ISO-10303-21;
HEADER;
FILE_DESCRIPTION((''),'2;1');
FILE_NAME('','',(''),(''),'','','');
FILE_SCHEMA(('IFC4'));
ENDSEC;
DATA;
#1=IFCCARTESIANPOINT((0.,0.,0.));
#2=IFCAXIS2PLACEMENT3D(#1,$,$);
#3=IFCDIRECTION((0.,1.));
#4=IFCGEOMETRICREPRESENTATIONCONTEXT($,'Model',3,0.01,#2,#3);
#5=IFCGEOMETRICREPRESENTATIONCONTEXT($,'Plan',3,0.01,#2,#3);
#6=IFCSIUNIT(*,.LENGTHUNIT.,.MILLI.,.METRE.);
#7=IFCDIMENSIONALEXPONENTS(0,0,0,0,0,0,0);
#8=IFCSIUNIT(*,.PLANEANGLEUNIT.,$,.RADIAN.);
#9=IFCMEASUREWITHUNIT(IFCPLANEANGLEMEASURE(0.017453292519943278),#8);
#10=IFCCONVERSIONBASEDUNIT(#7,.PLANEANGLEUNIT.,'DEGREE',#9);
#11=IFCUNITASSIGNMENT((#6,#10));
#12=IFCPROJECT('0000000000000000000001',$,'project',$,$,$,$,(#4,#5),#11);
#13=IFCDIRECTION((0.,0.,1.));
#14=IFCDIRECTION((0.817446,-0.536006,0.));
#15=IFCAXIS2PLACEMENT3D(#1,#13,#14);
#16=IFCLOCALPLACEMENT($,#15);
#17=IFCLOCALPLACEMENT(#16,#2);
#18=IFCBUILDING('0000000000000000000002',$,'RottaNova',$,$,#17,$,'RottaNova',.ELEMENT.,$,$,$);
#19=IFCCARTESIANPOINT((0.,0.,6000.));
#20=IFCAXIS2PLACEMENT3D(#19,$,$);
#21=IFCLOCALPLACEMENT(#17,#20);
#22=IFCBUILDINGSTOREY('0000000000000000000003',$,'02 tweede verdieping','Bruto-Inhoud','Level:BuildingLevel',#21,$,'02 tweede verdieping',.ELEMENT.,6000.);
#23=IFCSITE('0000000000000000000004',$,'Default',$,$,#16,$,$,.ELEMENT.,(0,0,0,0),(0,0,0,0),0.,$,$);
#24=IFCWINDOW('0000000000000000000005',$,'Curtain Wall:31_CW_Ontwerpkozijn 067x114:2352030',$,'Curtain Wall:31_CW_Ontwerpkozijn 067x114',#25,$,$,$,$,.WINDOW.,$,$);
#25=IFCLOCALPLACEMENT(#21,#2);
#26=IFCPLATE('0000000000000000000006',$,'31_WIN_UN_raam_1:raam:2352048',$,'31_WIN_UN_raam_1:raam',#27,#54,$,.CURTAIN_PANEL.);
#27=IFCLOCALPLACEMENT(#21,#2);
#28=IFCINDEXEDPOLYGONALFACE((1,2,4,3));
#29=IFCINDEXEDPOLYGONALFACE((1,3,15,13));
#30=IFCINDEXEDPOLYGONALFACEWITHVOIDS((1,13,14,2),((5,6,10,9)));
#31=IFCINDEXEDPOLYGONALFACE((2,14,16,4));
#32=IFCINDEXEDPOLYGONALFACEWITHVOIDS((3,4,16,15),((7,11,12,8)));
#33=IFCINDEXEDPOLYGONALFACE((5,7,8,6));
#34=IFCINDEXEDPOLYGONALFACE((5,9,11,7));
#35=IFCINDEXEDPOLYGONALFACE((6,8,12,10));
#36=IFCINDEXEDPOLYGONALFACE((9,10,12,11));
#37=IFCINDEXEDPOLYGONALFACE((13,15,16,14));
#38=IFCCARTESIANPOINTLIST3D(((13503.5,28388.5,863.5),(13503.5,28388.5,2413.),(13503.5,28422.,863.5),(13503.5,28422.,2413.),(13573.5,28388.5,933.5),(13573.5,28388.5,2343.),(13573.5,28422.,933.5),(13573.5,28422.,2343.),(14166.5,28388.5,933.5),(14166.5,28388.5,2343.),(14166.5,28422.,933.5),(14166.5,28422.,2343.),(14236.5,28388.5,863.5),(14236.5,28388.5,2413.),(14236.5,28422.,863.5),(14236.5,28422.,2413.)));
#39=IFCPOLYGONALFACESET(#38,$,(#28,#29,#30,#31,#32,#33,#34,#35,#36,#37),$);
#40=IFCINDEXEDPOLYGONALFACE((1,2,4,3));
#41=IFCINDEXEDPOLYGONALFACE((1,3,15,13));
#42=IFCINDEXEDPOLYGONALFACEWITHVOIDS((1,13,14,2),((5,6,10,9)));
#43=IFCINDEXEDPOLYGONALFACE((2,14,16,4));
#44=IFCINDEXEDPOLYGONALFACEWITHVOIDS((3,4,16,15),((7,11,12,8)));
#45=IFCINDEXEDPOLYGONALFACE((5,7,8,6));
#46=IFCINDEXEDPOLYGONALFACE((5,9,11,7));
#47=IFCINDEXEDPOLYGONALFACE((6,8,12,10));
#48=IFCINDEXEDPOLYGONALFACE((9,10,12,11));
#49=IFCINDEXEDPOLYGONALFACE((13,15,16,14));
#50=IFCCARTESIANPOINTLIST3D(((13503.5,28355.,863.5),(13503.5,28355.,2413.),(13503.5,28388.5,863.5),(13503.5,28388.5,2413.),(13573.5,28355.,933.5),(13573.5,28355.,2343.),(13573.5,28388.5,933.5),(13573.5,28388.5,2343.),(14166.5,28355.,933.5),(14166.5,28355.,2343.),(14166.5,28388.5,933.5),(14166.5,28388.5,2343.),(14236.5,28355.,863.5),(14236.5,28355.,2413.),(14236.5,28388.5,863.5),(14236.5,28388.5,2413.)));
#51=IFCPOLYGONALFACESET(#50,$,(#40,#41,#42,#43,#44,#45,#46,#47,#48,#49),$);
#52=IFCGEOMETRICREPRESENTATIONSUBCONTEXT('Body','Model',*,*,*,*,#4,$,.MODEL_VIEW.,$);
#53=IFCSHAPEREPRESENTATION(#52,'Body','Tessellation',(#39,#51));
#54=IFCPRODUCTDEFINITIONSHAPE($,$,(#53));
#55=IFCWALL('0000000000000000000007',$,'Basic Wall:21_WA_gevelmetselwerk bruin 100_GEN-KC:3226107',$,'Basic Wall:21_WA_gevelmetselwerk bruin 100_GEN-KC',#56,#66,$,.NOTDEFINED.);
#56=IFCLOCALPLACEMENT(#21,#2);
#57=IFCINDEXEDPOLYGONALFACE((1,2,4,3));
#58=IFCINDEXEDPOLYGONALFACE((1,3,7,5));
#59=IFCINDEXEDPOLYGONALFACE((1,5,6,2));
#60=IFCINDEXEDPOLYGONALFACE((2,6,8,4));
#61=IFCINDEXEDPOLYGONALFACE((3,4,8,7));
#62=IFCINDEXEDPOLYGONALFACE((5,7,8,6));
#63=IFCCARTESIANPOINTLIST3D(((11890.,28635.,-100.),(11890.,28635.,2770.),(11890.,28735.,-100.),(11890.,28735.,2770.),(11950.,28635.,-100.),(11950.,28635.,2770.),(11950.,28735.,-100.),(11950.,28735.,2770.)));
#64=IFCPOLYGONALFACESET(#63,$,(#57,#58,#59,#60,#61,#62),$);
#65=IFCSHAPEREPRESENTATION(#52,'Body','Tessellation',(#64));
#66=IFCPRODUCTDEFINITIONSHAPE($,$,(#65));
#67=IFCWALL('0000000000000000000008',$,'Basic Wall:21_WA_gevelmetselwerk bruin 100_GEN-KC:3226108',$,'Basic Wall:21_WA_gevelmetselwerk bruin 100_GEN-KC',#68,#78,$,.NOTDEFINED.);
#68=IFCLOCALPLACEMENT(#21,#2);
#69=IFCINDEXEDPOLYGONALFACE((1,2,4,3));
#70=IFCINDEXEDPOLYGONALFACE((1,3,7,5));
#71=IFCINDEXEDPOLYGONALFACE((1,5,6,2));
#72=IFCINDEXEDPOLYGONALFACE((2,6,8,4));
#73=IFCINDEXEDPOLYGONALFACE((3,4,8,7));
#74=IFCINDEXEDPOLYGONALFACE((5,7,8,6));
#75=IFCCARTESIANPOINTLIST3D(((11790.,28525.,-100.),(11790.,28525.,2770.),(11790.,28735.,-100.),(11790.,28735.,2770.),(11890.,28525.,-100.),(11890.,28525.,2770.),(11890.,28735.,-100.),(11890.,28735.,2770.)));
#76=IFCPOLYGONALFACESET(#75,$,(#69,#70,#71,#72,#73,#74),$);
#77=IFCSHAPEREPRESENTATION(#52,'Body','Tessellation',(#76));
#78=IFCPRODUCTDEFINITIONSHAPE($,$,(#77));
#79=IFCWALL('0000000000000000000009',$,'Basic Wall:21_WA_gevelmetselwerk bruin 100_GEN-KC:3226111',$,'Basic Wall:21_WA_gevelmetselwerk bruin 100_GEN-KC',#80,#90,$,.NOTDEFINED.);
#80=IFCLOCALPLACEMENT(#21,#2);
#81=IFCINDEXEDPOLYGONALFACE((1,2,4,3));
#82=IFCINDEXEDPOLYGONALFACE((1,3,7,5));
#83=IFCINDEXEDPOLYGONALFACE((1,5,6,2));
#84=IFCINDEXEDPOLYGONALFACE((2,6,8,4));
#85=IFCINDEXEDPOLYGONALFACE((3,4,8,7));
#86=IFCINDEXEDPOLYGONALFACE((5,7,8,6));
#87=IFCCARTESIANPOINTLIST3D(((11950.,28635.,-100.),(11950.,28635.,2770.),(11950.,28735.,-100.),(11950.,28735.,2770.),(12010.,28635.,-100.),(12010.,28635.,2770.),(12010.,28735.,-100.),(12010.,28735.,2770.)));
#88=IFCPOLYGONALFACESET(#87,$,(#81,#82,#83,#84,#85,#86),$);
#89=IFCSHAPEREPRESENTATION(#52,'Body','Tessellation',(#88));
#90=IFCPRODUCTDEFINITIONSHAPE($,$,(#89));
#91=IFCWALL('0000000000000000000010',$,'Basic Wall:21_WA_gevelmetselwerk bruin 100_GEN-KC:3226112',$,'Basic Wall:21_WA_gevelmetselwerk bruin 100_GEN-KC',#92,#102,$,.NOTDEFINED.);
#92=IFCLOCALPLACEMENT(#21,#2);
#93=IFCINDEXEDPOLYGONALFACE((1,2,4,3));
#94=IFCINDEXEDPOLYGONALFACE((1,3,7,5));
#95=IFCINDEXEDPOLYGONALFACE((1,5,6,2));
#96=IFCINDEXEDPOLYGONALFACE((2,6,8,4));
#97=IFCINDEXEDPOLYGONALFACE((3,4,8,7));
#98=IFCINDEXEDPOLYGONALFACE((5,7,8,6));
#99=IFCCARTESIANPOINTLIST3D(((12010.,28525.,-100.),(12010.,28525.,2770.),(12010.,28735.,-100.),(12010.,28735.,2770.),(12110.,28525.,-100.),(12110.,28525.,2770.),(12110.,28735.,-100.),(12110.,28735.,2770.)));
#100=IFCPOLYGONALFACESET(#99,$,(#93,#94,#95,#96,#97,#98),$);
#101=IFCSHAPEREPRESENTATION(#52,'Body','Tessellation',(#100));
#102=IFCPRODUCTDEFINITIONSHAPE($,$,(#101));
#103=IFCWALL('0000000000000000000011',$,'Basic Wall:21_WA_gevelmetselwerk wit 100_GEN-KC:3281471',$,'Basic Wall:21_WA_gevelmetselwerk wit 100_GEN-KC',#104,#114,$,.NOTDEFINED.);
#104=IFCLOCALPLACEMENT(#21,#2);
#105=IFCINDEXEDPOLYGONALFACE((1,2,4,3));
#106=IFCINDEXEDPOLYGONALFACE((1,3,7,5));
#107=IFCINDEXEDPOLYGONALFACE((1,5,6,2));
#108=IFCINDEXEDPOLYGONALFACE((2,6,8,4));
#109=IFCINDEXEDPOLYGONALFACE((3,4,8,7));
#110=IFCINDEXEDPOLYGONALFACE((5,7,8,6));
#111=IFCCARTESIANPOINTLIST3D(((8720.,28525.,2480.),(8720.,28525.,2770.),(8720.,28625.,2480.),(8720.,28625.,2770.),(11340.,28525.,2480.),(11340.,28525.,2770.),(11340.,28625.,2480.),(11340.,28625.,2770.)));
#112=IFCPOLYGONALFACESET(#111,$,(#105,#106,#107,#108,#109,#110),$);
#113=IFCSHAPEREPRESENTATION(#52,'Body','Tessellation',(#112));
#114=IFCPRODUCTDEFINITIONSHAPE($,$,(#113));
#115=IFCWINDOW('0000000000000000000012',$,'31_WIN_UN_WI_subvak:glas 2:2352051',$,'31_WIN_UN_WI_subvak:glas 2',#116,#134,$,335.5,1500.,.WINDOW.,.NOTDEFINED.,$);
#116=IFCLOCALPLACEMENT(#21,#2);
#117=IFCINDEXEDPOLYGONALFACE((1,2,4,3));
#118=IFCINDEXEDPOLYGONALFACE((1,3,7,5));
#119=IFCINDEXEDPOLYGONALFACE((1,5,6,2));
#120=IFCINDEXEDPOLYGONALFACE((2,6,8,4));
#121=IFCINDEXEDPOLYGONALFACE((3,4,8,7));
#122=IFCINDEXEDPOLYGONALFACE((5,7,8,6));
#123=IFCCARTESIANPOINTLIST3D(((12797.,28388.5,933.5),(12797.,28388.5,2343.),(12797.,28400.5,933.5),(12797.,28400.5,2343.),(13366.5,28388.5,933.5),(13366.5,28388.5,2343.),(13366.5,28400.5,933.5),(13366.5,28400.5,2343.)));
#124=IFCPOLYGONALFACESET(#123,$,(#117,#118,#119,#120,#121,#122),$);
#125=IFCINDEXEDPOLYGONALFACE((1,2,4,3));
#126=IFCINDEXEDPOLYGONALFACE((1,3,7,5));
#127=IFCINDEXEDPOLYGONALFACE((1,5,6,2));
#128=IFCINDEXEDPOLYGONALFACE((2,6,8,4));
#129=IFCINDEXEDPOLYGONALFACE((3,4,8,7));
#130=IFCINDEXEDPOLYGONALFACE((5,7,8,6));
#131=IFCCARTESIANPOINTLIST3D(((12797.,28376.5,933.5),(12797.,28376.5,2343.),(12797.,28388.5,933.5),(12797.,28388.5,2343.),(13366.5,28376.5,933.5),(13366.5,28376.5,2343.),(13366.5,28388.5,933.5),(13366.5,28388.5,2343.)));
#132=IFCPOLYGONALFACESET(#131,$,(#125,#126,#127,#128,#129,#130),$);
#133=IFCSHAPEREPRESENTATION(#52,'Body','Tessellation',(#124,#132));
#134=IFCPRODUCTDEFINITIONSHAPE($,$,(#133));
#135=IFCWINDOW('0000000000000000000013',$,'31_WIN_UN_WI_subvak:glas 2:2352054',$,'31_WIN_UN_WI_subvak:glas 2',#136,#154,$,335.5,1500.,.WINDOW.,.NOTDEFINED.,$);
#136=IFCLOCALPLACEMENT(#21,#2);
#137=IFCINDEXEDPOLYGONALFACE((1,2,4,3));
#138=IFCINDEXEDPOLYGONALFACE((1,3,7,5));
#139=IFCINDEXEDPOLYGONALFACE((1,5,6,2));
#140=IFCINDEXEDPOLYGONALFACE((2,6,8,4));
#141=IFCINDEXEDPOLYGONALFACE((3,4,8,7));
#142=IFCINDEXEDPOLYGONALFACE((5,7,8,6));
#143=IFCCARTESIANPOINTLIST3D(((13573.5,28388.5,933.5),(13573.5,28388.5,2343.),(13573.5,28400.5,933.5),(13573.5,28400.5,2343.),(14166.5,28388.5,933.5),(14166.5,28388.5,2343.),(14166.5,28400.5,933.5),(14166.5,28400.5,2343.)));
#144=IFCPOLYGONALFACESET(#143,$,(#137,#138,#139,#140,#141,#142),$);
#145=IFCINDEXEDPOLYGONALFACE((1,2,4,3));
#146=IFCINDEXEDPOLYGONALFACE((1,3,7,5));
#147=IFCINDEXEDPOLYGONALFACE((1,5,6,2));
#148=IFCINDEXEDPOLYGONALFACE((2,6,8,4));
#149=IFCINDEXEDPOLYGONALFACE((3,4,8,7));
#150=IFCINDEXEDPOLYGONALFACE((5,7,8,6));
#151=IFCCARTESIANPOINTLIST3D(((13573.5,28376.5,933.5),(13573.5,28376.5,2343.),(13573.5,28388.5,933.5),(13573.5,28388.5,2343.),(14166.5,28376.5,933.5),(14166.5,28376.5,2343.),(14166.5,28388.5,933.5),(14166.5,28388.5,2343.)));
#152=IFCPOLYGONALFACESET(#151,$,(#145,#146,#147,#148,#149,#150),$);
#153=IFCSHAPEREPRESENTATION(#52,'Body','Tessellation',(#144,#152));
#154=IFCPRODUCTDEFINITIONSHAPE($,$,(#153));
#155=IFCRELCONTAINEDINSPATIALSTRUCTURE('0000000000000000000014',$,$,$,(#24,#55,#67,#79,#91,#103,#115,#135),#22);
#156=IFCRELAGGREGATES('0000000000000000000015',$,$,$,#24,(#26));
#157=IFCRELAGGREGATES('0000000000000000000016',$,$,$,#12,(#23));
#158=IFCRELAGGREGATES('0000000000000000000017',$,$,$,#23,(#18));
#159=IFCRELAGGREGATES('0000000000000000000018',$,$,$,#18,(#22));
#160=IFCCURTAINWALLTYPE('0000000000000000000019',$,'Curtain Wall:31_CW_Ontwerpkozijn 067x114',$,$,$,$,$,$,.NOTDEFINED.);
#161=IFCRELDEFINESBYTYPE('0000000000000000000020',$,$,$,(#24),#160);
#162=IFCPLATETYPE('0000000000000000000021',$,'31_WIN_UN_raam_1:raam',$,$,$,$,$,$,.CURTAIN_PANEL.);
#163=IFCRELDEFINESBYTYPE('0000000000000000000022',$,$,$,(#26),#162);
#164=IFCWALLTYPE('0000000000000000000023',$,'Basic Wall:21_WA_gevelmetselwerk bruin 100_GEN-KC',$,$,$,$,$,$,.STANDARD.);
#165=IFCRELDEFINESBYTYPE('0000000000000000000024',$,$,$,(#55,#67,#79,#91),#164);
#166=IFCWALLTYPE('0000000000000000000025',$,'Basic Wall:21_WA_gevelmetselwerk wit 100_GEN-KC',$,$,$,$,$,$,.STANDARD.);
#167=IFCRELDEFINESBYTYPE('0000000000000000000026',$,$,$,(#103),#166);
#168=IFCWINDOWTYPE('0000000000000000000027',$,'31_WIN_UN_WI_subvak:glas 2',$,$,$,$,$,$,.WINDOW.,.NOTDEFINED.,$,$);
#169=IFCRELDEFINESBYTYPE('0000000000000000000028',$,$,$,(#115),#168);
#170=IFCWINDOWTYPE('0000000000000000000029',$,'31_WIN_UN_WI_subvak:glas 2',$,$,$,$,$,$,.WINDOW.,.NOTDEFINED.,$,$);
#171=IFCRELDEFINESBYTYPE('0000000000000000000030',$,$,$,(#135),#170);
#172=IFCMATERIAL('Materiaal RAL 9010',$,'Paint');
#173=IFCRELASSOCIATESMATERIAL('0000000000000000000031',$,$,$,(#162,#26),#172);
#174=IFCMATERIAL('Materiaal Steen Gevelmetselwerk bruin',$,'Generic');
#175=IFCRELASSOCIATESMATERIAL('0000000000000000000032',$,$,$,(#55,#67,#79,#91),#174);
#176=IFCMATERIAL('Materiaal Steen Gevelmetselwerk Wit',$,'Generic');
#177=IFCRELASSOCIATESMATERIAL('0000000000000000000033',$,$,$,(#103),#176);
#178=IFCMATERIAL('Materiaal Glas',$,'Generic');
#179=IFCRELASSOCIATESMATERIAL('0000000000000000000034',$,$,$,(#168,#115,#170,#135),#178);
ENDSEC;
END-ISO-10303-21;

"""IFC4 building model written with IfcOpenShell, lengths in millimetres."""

from ifc_helpers import new_model, entity, si_unit, converted_unit, direction, frame, origin, place, context, subcontext, project, spatial, indexed_curve, outline, extrude, source, transform, mapped, material, type_object, type_shapes, element, aggregate, save


model = new_model("IFC4")

# Units and contexts
model_context = context("Model", 3, precision=0.01, world=origin(), true_north=direction((0.0, 1.0)))
plan_context = context("Plan", 3, precision=0.01, world=origin(), true_north=direction((0.0, 1.0)))
body_context = subcontext(model_context, "Body", "Model", "MODEL_VIEW")
ifc_project = project(units=[si_unit("LENGTHUNIT", "METRE", prefix="MILLI"), converted_unit("PLANEANGLEUNIT", "DEGREE", entity("IfcPlaneAngleMeasure", 0.017453292519943278), si_unit("PLANEANGLEUNIT", "RADIAN"), dimensions=[0, 0, 0, 0, 0, 0, 0])], contexts=[model_context, plan_context])

# Site, building, storey
site_placement = place(None, frame((0.0, 0.0, 0.0), z_axis=(0.0, 0.0, 1.0), x_axis=(0.817446, -0.536006, 0.0)))
site = spatial("IfcSite", under=ifc_project, at=site_placement, Name="Default", CompositionType="ELEMENT", RefLatitude=(0, 0, 0, 0), RefLongitude=(0, 0, 0, 0), RefElevation=0.0)
building_placement = place(site_placement, origin())
building = spatial("IfcBuilding", under=site, at=building_placement, Name="RottaNova", LongName="RottaNova", CompositionType="ELEMENT")
storey_placement = place(building_placement, frame((0.0, 0.0, 6000.0)))
storey = spatial("IfcBuildingStorey", under=building, at=storey_placement, Name="02 tweede verdieping", Description="Bruto-Inhoud", ObjectType="Level:BuildingLevel", LongName="02 tweede verdieping", CompositionType="ELEMENT", Elevation=6000.0)

# Window
curtain_wall_type = type_object("IfcCurtainWallType", Name="Curtain Wall:31_CW_Ontwerpkozijn 067x114", PredefinedType="NOTDEFINED")
window_1_placement = place(storey_placement, frame((0.0, 0.0, -6000.0)))
window_1 = element("IfcWindow", 1, at=window_1_placement, inside=storey, type_object=curtain_wall_type, Name="Curtain Wall:31_CW_Ontwerpkozijn 067x114:2352030", ObjectType="Curtain Wall:31_CW_Ontwerpkozijn 067x114", PredefinedType="WINDOW")
ifc_material_1 = material(Name="Materiaal RAL 9010", Category="Paint")

# Plate
ifc_material_2 = material(Name="Materiaal Glas", Category="Generic")
plate_type_1 = type_object("IfcPlateType", Name="31_WIN_UN_raam_1:raam", PredefinedType="CURTAIN_PANEL", material=ifc_material_1)
shared_shape_1 = source(origin(), body_context, "Body", "SweptSolid", [
    extrude(outline(indexed_curve([(-366.5, -774.8), (366.5, -774.8), (366.5, 774.8), (-366.5, 774.8), (-366.5, -774.8)], self_intersect=False), holes=[indexed_curve([(-296.5, 704.8), (296.5, 704.8), (296.5, -704.8), (-296.5, -704.8), (-296.5, 704.8)], self_intersect=False)]), frame((0.0, 58.5, 774.8), z_axis=(0.0, 1.0, 0.0), x_axis=(1.0, 0.0, 0.0)), (0.0, 0.0, 1.0), 33.5),
    extrude(outline(indexed_curve([(-366.5, -774.8), (366.5, -774.8), (366.5, 774.8), (-366.5, 774.8), (-366.5, -774.8)], self_intersect=False), holes=[indexed_curve([(-296.5, 704.7), (296.5, 704.7), (296.5, -704.8), (-296.5, -704.8), (-296.5, 704.7)], self_intersect=False)]), frame((0.0, 25.0, 774.8), z_axis=(0.0, 1.0, 0.0), x_axis=(1.0, 0.0, 0.0)), (0.0, 0.0, 1.0), 33.5),
])
type_shapes(plate_type_1, [shared_shape_1])
plate_1_placement = place(window_1_placement, frame((13870.0, 28330.0, 6863.5)))
plate_1 = element("IfcPlate", 2, at=plate_1_placement, type_object=plate_type_1, material=ifc_material_1, Name="31_WIN_UN_raam_1:raam:2352048", ObjectType="31_WIN_UN_raam_1:raam", PredefinedType="CURTAIN_PANEL", context=body_context, shape_type="MappedRepresentation", body=[
    mapped(shared_shape_1, transform((0.0, 0.0, 0.0), scale=1.0)),
])
aggregate(window_1, [plate_1])

# Walls
ifc_material_3 = material(Name="Materiaal Steen Gevelmetselwerk bruin", Category="Generic")
wall_type_1 = type_object("IfcWallType", Name="Basic Wall:21_WA_gevelmetselwerk bruin 100_GEN-KC", PredefinedType="STANDARD")
wall_1_placement = place(storey_placement, frame((11890.0, 28685.0, -100.0)))
element("IfcWall", 3, at=wall_1_placement, inside=storey, type_object=wall_type_1, material=ifc_material_3, Name="Basic Wall:21_WA_gevelmetselwerk bruin 100_GEN-KC:3226107", ObjectType="Basic Wall:21_WA_gevelmetselwerk bruin 100_GEN-KC", PredefinedType="NOTDEFINED", context=body_context, shape_type="SweptSolid", body=[
    extrude(outline(indexed_curve([(60.0, 50.0), (0.0, 50.0), (0.0, -50.0), (60.0, -50.0), (60.0, 50.0)], self_intersect=False)), origin(), (0.0, 0.0, 1.0), 2870.0),
])
wall_2_placement = place(storey_placement, frame((11840.0, 28735.0, -100.0), z_axis=(0.0, 0.0, 1.0), x_axis=(0.0, -1.0, 0.0)))
element("IfcWall", 4, at=wall_2_placement, inside=storey, type_object=wall_type_1, material=ifc_material_3, Name="Basic Wall:21_WA_gevelmetselwerk bruin 100_GEN-KC:3226108", ObjectType="Basic Wall:21_WA_gevelmetselwerk bruin 100_GEN-KC", PredefinedType="NOTDEFINED", context=body_context, shape_type="SweptSolid", body=[
    extrude(outline(indexed_curve([(210.0, 50.0), (0.0, 50.0), (0.0, -50.0), (210.0, -50.0), (210.0, 50.0)], self_intersect=False)), origin(), (0.0, 0.0, 1.0), 2870.0),
])
wall_3_placement = place(storey_placement, frame((12010.0, 28685.0, -100.0), z_axis=(0.0, 0.0, 1.0), x_axis=(-1.0, 0.0, 0.0)))
element("IfcWall", 5, at=wall_3_placement, inside=storey, type_object=wall_type_1, material=ifc_material_3, Name="Basic Wall:21_WA_gevelmetselwerk bruin 100_GEN-KC:3226111", ObjectType="Basic Wall:21_WA_gevelmetselwerk bruin 100_GEN-KC", PredefinedType="NOTDEFINED", context=body_context, shape_type="SweptSolid", body=[
    extrude(outline(indexed_curve([(60.0, 50.0), (0.0, 50.0), (0.0, -50.0), (60.0, -50.0), (60.0, 50.0)], self_intersect=False)), origin(), (0.0, 0.0, 1.0), 2870.0),
])
wall_4_placement = place(storey_placement, frame((12060.0, 28735.0, -100.0), z_axis=(0.0, 0.0, 1.0), x_axis=(0.0, -1.0, 0.0)))
element("IfcWall", 6, at=wall_4_placement, inside=storey, type_object=wall_type_1, material=ifc_material_3, Name="Basic Wall:21_WA_gevelmetselwerk bruin 100_GEN-KC:3226112", ObjectType="Basic Wall:21_WA_gevelmetselwerk bruin 100_GEN-KC", PredefinedType="NOTDEFINED", context=body_context, shape_type="SweptSolid", body=[
    extrude(outline(indexed_curve([(210.0, 50.0), (0.0, 50.0), (0.0, -50.0), (210.0, -50.0), (210.0, 50.0)], self_intersect=False)), origin(), (0.0, 0.0, 1.0), 2870.0),
])
ifc_material_4 = material(Name="Materiaal Steen Gevelmetselwerk Wit", Category="Generic")
wall_type_2 = type_object("IfcWallType", Name="Basic Wall:21_WA_gevelmetselwerk wit 100_GEN-KC", PredefinedType="STANDARD")
wall_5_placement = place(storey_placement, frame((11340.0, 28575.0, 2480.0), z_axis=(0.0, 0.0, 1.0), x_axis=(-1.0, 0.0, 0.0)))
element("IfcWall", 7, at=wall_5_placement, inside=storey, type_object=wall_type_2, material=ifc_material_4, Name="Basic Wall:21_WA_gevelmetselwerk wit 100_GEN-KC:3281471", ObjectType="Basic Wall:21_WA_gevelmetselwerk wit 100_GEN-KC", PredefinedType="NOTDEFINED", context=body_context, shape_type="SweptSolid", body=[
    extrude(outline(indexed_curve([(2620.0, 50.0), (0.0, 50.0), (0.0, -50.0), (2620.0, -50.0), (2620.0, 50.0)], self_intersect=False)), origin(), (0.0, 0.0, 1.0), 290.0),
])

# Windows
window_type_1 = type_object("IfcWindowType", Name="31_WIN_UN_WI_subvak:glas 2", PartitioningType="NOTDEFINED", PredefinedType="WINDOW", material=ifc_material_2)
shared_shape_2 = source(origin(), body_context, "Body", "SweptSolid", [
    extrude(outline(indexed_curve([(-6.0, -284.7), (6.0, -284.7), (6.0, 284.7), (-6.0, 284.7), (-6.0, -284.7)], self_intersect=False)), frame((0.0, 6.0, 0.0), z_axis=(0.0, 0.0, 1.0), x_axis=(0.0, -1.0, 0.0)), (0.0, 0.0, 1.0), 1409.5),
    extrude(outline(indexed_curve([(-6.0, -284.8), (6.0, -284.8), (6.0, 284.8), (-6.0, 284.8), (-6.0, -284.8)], self_intersect=False)), frame((0.0, -6.0, 0.0), z_axis=(0.0, 0.0, 1.0), x_axis=(0.0, -1.0, 0.0)), (0.0, 0.0, 1.0), 1409.5),
])
type_shapes(window_type_1, [shared_shape_2])
window_2_placement = place(storey_placement, frame((13081.8, 28388.5, 933.5)))
element("IfcWindow", 8, at=window_2_placement, inside=storey, type_object=window_type_1, material=ifc_material_2, Name="31_WIN_UN_WI_subvak:glas 2:2352051", ObjectType="31_WIN_UN_WI_subvak:glas 2", OverallHeight=335.5, OverallWidth=1500.0, PartitioningType="NOTDEFINED", PredefinedType="WINDOW", context=body_context, shape_type="MappedRepresentation", body=[
    mapped(shared_shape_2, transform((0.0, 0.0, 0.0), scale=1.0)),
])
window_type_2 = type_object("IfcWindowType", Name="31_WIN_UN_WI_subvak:glas 2", PartitioningType="NOTDEFINED", PredefinedType="WINDOW", material=ifc_material_2)
shared_shape_3 = source(origin(), body_context, "Body", "SweptSolid", [
    extrude(outline(indexed_curve([(-6.0, -296.5), (6.0, -296.5), (6.0, 296.5), (-6.0, 296.5), (-6.0, -296.5)], self_intersect=False)), frame((0.0, 6.0, 0.0), z_axis=(0.0, 0.0, 1.0), x_axis=(0.0, -1.0, 0.0)), (0.0, 0.0, 1.0), 1409.5),
    extrude(outline(indexed_curve([(-6.0, -296.5), (6.0, -296.5), (6.0, 296.5), (-6.0, 296.5), (-6.0, -296.5)], self_intersect=False)), frame((0.0, -6.0, 0.0), z_axis=(0.0, 0.0, 1.0), x_axis=(0.0, -1.0, 0.0)), (0.0, 0.0, 1.0), 1409.5),
])
type_shapes(window_type_2, [shared_shape_3])
window_3_placement = place(storey_placement, frame((13870.0, 28388.5, 933.5)))
element("IfcWindow", 9, at=window_3_placement, inside=storey, type_object=window_type_2, material=ifc_material_2, Name="31_WIN_UN_WI_subvak:glas 2:2352054", ObjectType="31_WIN_UN_WI_subvak:glas 2", OverallHeight=335.5, OverallWidth=1500.0, PartitioningType="NOTDEFINED", PredefinedType="WINDOW", context=body_context, shape_type="MappedRepresentation", body=[
    mapped(shared_shape_3, transform((0.0, 0.0, 0.0), scale=1.0)),
])

save(model, "model.ifc")
